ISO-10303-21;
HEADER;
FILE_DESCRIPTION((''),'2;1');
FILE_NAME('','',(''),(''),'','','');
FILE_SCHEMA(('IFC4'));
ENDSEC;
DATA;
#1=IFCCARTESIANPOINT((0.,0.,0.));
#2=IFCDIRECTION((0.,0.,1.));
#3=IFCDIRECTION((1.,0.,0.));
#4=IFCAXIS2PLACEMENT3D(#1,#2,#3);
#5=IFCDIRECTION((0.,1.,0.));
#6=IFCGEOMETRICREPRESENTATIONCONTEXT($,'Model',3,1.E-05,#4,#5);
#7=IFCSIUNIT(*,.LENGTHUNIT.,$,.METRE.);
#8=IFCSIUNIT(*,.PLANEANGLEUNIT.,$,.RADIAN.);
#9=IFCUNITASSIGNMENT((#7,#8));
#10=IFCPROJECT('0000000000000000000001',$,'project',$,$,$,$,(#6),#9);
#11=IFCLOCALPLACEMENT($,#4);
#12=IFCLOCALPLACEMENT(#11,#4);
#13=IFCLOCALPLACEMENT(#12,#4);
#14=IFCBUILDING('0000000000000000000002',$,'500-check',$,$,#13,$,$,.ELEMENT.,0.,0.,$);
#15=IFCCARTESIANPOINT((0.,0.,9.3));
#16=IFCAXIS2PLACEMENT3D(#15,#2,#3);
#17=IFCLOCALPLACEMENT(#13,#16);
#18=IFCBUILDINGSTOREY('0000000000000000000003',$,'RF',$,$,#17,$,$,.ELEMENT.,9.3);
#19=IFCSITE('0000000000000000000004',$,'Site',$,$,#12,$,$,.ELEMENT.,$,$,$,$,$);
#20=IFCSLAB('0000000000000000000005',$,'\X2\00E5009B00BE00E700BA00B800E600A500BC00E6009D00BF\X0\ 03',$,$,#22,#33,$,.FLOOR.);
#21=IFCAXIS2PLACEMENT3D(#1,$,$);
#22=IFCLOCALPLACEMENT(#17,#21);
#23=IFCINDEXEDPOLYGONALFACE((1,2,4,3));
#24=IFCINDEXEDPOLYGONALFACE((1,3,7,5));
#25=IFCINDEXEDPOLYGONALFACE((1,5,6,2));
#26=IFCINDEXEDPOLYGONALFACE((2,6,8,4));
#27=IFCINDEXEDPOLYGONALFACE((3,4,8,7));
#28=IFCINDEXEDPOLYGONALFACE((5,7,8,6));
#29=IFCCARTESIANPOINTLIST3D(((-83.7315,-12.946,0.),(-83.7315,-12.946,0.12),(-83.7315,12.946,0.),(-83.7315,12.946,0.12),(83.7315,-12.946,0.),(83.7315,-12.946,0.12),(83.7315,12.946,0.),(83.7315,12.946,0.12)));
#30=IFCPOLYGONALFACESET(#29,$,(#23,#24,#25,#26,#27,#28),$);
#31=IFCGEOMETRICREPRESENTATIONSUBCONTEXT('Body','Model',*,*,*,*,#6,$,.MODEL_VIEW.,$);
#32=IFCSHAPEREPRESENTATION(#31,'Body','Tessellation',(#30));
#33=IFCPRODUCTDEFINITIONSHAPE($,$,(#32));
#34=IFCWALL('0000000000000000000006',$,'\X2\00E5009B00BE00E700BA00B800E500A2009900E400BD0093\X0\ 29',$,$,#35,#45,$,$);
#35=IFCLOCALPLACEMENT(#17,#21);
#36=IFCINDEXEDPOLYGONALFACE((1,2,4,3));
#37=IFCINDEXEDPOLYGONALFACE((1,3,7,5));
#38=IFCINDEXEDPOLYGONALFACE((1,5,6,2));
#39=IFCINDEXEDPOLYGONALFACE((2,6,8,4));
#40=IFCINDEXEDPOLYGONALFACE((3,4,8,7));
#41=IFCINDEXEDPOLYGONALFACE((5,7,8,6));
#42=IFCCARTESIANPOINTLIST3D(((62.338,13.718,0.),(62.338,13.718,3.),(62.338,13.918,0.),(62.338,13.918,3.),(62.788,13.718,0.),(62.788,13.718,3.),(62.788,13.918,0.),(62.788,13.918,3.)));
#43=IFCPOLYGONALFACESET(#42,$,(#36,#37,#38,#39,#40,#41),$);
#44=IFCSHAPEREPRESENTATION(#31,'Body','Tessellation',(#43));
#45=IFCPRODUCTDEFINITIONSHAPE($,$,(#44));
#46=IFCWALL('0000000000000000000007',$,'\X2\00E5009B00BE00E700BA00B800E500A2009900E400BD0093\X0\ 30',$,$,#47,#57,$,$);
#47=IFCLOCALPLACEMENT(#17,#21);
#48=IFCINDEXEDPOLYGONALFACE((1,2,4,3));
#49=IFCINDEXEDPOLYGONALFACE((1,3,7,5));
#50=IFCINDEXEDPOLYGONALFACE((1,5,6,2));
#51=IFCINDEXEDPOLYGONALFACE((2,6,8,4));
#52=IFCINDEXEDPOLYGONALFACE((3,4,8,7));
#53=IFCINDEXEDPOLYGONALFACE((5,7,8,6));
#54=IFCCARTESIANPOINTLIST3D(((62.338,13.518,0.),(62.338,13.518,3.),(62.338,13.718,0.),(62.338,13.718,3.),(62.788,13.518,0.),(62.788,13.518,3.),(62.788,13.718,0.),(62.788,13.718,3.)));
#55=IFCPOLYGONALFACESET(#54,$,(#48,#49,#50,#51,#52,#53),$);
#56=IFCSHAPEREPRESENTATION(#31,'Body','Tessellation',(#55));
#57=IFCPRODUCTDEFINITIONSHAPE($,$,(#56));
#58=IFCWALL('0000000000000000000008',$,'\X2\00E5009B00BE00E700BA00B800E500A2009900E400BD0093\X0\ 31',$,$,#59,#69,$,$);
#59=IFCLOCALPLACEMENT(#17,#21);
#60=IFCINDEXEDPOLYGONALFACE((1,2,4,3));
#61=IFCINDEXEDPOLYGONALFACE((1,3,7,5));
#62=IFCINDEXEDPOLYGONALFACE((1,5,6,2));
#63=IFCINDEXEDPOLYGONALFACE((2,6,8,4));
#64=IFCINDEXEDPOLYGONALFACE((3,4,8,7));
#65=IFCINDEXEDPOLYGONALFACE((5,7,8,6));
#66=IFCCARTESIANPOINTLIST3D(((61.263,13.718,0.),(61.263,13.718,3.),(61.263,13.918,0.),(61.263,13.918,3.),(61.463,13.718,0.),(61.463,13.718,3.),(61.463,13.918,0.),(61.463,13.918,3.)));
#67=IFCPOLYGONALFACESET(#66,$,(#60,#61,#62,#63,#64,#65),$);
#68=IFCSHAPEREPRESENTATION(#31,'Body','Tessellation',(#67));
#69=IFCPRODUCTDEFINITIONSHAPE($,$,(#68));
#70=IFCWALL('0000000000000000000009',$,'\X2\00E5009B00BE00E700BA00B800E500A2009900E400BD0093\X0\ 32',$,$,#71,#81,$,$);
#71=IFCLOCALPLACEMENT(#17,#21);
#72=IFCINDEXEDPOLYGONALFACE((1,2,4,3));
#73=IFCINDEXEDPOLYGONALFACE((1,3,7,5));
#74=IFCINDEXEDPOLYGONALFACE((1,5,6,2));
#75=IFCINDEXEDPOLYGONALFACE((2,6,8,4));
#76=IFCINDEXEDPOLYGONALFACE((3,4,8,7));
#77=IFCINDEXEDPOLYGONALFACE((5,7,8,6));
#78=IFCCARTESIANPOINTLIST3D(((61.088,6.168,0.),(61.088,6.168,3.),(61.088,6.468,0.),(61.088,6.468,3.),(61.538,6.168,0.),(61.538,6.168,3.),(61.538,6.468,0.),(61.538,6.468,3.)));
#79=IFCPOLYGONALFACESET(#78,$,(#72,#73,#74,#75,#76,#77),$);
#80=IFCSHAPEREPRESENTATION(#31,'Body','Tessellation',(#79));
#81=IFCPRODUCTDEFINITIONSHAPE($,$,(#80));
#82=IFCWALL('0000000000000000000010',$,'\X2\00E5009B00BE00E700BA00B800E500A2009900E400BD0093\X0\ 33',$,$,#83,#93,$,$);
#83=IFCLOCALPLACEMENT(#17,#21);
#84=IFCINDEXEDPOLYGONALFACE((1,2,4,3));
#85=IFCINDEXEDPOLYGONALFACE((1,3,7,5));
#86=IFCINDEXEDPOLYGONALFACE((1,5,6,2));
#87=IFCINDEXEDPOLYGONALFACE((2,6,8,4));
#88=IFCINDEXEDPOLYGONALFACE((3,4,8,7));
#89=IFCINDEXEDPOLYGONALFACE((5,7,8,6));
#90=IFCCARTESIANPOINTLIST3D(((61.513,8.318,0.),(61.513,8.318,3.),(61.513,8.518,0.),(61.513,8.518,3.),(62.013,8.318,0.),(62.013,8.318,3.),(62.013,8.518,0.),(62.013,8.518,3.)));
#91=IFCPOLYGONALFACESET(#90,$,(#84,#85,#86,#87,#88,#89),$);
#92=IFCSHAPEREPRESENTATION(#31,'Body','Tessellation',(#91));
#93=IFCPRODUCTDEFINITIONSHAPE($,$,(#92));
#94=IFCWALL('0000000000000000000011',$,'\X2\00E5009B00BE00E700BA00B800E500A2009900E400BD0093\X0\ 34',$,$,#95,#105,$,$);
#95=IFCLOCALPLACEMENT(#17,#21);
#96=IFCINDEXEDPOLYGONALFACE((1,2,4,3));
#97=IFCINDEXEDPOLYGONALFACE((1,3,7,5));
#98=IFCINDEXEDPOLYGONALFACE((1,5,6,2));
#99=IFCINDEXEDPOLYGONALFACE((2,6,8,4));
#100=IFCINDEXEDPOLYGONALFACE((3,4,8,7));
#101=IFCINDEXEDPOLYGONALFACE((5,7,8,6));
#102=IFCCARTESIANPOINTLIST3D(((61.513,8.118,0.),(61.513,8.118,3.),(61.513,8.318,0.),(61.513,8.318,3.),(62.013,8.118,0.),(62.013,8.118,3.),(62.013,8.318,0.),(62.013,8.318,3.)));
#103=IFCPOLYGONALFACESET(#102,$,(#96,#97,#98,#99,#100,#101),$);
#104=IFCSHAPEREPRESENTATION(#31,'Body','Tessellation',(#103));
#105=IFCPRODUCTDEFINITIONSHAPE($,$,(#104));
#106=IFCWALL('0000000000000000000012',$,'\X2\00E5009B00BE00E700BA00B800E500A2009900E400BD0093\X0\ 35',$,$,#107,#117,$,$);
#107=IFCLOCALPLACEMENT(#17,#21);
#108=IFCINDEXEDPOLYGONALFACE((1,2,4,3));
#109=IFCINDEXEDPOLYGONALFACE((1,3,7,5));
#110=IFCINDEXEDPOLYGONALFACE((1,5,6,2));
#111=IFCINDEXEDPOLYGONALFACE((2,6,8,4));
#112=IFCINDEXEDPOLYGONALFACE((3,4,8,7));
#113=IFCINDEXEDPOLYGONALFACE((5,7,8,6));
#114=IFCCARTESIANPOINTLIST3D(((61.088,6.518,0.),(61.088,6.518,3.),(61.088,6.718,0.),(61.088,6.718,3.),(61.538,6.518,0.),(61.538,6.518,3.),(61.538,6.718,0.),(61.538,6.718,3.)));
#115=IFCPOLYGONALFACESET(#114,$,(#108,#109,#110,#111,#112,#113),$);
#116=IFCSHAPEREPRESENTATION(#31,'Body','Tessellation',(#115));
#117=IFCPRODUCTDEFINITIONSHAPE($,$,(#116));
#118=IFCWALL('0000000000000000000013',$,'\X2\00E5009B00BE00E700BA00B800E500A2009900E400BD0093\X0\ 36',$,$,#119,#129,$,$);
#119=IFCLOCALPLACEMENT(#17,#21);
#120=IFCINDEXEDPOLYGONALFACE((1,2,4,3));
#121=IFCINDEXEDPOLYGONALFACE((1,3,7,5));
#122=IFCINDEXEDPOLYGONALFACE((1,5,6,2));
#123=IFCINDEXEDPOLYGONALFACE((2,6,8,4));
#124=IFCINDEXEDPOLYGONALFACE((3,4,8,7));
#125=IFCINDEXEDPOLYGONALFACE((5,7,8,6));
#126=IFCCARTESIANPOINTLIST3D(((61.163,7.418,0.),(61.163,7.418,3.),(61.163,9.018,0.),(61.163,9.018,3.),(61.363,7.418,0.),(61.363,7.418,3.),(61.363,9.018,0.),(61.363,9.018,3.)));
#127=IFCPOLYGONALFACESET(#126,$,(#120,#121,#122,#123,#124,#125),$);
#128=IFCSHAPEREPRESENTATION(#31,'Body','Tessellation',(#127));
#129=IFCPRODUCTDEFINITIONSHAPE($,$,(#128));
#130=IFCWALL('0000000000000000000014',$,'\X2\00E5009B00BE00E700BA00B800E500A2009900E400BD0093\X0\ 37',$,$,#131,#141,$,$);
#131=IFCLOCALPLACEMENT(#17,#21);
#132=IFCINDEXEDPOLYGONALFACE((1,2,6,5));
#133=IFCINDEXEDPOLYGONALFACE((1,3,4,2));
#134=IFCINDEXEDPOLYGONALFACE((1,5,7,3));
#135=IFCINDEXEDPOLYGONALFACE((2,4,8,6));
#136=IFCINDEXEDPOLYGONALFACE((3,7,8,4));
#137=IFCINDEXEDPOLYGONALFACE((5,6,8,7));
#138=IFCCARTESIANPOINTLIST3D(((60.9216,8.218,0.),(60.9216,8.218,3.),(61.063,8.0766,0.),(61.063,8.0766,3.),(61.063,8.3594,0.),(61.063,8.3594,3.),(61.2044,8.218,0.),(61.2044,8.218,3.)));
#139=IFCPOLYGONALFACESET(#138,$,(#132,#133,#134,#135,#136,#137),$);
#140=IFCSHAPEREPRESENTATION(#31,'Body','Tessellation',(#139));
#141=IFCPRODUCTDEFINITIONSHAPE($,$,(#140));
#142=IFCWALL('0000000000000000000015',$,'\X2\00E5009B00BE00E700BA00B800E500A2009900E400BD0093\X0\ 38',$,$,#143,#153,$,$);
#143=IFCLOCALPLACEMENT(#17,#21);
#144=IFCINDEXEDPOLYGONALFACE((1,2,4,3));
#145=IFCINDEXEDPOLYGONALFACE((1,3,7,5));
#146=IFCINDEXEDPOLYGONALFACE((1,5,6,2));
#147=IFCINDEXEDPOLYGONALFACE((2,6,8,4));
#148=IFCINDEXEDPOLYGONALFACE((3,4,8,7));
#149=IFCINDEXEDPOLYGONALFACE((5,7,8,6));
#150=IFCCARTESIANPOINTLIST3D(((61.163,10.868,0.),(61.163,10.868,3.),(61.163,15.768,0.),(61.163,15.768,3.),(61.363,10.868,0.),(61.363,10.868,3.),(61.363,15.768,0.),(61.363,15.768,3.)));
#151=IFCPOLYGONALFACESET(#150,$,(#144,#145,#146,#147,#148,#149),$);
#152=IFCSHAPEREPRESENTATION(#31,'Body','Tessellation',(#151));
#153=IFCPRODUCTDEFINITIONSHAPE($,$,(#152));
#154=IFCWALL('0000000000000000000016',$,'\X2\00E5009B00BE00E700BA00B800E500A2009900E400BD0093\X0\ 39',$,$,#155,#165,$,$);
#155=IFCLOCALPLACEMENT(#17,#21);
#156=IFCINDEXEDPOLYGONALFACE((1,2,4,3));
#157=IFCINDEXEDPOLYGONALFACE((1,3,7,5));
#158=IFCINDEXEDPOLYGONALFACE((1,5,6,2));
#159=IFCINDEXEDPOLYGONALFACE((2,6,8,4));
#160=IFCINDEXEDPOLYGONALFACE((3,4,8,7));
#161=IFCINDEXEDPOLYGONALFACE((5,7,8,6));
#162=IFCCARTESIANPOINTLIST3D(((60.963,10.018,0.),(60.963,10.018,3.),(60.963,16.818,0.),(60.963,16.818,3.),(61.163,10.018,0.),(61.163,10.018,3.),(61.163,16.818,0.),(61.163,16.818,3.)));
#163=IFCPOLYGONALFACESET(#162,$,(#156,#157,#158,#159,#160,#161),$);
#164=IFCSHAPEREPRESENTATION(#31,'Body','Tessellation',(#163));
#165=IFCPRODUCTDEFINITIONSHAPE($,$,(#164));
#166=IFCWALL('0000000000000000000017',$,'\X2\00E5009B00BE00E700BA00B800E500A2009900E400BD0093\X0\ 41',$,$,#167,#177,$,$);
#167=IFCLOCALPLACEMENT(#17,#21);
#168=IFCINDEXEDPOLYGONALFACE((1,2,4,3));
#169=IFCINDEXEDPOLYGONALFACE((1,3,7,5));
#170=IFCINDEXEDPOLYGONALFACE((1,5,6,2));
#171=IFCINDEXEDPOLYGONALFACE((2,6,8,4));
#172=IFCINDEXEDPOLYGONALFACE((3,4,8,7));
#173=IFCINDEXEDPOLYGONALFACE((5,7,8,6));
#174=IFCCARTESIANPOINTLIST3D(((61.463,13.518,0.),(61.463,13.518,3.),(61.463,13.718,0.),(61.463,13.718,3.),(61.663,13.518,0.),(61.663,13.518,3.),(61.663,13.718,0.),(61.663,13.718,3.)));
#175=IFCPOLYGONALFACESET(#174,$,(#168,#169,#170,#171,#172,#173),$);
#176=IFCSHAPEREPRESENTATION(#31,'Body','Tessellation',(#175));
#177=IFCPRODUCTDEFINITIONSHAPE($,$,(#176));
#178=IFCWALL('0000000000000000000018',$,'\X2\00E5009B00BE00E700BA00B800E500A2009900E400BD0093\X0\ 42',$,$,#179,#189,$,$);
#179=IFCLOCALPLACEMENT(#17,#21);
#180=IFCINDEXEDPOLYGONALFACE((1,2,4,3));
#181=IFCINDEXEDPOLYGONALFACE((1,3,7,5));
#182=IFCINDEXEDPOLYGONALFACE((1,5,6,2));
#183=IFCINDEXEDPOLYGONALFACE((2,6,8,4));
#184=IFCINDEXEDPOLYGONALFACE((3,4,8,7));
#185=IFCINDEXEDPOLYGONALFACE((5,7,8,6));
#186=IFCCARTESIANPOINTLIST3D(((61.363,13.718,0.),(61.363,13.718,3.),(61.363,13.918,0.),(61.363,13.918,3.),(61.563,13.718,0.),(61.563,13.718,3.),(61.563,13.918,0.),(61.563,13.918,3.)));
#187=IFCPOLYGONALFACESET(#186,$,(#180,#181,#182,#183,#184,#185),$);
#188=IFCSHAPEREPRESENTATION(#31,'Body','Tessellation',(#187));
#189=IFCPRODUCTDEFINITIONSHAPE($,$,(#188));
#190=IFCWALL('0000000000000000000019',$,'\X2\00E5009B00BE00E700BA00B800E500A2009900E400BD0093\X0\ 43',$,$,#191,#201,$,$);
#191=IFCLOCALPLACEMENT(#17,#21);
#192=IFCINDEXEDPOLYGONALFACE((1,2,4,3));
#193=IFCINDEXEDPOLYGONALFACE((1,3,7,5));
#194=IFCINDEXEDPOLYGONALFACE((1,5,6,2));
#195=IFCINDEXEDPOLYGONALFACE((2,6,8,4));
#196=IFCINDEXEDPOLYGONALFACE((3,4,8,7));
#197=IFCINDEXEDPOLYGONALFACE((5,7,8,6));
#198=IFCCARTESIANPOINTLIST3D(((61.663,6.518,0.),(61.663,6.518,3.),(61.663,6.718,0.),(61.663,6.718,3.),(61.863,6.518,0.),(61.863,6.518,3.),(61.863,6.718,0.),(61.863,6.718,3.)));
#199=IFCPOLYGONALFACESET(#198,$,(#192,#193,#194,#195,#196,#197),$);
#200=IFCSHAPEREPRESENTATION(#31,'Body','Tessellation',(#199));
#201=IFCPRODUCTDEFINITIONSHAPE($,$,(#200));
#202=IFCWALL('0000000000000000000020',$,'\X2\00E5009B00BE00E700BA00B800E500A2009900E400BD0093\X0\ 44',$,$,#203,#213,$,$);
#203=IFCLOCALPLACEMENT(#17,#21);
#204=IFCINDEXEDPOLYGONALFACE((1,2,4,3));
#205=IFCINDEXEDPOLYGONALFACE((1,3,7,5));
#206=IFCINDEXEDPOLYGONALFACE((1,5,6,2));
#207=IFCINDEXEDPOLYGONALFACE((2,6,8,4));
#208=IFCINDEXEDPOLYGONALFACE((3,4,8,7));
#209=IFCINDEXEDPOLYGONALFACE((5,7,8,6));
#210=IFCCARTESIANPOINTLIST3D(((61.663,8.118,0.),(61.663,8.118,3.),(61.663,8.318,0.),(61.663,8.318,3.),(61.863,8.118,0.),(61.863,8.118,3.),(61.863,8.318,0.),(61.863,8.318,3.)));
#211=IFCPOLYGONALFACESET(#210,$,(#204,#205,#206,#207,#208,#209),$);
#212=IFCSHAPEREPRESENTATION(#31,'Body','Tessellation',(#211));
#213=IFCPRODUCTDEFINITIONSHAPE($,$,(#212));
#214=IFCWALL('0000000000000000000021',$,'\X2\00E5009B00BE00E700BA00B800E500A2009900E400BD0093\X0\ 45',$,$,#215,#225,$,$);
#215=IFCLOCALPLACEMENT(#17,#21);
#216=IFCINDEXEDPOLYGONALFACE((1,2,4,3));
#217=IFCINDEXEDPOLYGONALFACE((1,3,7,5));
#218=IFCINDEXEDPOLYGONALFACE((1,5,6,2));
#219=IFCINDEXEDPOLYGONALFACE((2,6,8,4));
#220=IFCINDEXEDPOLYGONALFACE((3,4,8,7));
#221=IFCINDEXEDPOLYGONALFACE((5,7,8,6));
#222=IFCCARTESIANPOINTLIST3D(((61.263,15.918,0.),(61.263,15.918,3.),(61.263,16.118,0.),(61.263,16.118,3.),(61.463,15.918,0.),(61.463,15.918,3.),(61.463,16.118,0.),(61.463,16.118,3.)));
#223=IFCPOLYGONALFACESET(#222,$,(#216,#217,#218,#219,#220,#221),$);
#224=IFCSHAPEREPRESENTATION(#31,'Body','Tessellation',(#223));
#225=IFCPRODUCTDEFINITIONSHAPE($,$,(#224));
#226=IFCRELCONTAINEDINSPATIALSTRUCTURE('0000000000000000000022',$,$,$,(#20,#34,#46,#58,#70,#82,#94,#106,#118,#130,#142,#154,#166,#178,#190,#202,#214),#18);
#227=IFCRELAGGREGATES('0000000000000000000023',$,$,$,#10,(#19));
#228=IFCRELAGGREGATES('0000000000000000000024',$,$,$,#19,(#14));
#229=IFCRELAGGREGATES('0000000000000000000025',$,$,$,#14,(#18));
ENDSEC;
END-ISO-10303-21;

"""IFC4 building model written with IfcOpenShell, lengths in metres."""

from ifc_helpers import new_model, si_unit, direction, frame, frame_2d, origin_with_axes, place, context, subcontext, project, spatial, rectangle, extrude, element, save


model = new_model("IFC4")

# Units and contexts
model_context = context("Model", 3, precision=1e-05, world=origin_with_axes(), true_north=direction((0.0, 1.0, 0.0)))
body_context = subcontext(model_context, "Body", "Model", "MODEL_VIEW")
ifc_project = project(units=[si_unit("LENGTHUNIT", "METRE"), si_unit("PLANEANGLEUNIT", "RADIAN")], contexts=[model_context])

# Site, building, storey
placement = place(None, origin_with_axes())
site_placement = place(placement, origin_with_axes())
site = spatial("IfcSite", under=ifc_project, at=site_placement, Name="Site", CompositionType="ELEMENT")
building_placement = place(site_placement, origin_with_axes())
building = spatial("IfcBuilding", under=site, at=building_placement, Name="500-check", CompositionType="ELEMENT", ElevationOfRefHeight=0.0, ElevationOfTerrain=0.0)
storey_placement = place(building_placement, frame((0.0, 0.0, 9.3), z_axis=(0.0, 0.0, 1.0), x_axis=(1.0, 0.0, 0.0)))
storey = spatial("IfcBuildingStorey", under=building, at=storey_placement, Name="RF", CompositionType="ELEMENT", Elevation=9.3)

# Slab
slab_placement = place(storey_placement, origin_with_axes())
element("IfcSlab", 1, at=slab_placement, inside=storey, Name="å\u009b¾çº¸æ¥¼æ\u009d¿ 03", PredefinedType="FLOOR", context=body_context, shape_type="SweptSolid", body=[
    extrude(rectangle(XDim=167.463, YDim=25.892, at=frame_2d((0.0, 0.0), x_axis=(1.0, 0.0, 0.0))), frame((0.0, 0.0, 0.0), z_axis=(0.0, 0.0, 1.0)), (0.0, 0.0, 1.0), 0.12),
])

# Walls
for number, where, z_axis, x_axis, name in (
    (2, (62.563, 13.818, 0.0), (0.0, 0.0, 1.0), (1.0, 0.0, 0.0), "å\u009b¾çº¸å¢\u0099ä½\u0093 29"),
    (3, (62.563, 13.618, 0.0), (0.0, 0.0, 1.0), (1.0, 0.0, 0.0), "å\u009b¾çº¸å¢\u0099ä½\u0093 30"),
):
    element("IfcWall", number, at=place(storey_placement, frame(where, z_axis=z_axis, x_axis=x_axis)), inside=storey, Name=name, context=body_context, shape_type="SweptSolid", body=[
        extrude(rectangle(XDim=0.45, YDim=0.2, at=frame_2d((0.0, 0.0), x_axis=(1.0, 0.0, 0.0))), frame((0.0, 0.0, 0.0), z_axis=(0.0, 0.0, 1.0)), (0.0, 0.0, 1.0), 3.0),
    ])
wall_1_placement = place(storey_placement, frame((61.363, 13.818, 0.0), z_axis=(0.0, 0.0, 1.0), x_axis=(1.0, 0.0, 0.0)))
element("IfcWall", 4, at=wall_1_placement, inside=storey, Name="å\u009b¾çº¸å¢\u0099ä½\u0093 31", context=body_context, shape_type="SweptSolid", body=[
    extrude(rectangle(XDim=0.2, YDim=0.2, at=frame_2d((0.0, 0.0), x_axis=(1.0, 0.0, 0.0))), frame((0.0, 0.0, 0.0), z_axis=(0.0, 0.0, 1.0)), (0.0, 0.0, 1.0), 3.0),
])
wall_2_placement = place(storey_placement, frame((61.313, 6.318, 0.0), z_axis=(0.0, 0.0, 1.0), x_axis=(1.0, 0.0, 0.0)))
element("IfcWall", 5, at=wall_2_placement, inside=storey, Name="å\u009b¾çº¸å¢\u0099ä½\u0093 32", context=body_context, shape_type="SweptSolid", body=[
    extrude(rectangle(XDim=0.45, YDim=0.3, at=frame_2d((0.0, 0.0), x_axis=(1.0, 0.0, 0.0))), frame((0.0, 0.0, 0.0), z_axis=(0.0, 0.0, 1.0)), (0.0, 0.0, 1.0), 3.0),
])
for number, where, z_axis, x_axis, name in (
    (6, (61.763, 8.418, 0.0), (0.0, 0.0, 1.0), (-1.0, 0.0, 0.0), "å\u009b¾çº¸å¢\u0099ä½\u0093 33"),
    (7, (61.763, 8.218, 0.0), (0.0, 0.0, 1.0), (-1.0, 0.0, 0.0), "å\u009b¾çº¸å¢\u0099ä½\u0093 34"),
):
    element("IfcWall", number, at=place(storey_placement, frame(where, z_axis=z_axis, x_axis=x_axis)), inside=storey, Name=name, context=body_context, shape_type="SweptSolid", body=[
        extrude(rectangle(XDim=0.5, YDim=0.2, at=frame_2d((0.0, 0.0), x_axis=(1.0, 0.0, 0.0))), frame((0.0, 0.0, 0.0), z_axis=(0.0, 0.0, 1.0)), (0.0, 0.0, 1.0), 3.0),
    ])
wall_3_placement = place(storey_placement, frame((61.313, 6.618, 0.0), z_axis=(0.0, 0.0, 1.0), x_axis=(1.0, 0.0, 0.0)))
element("IfcWall", 8, at=wall_3_placement, inside=storey, Name="å\u009b¾çº¸å¢\u0099ä½\u0093 35", context=body_context, shape_type="SweptSolid", body=[
    extrude(rectangle(XDim=0.45, YDim=0.2, at=frame_2d((0.0, 0.0), x_axis=(1.0, 0.0, 0.0))), frame((0.0, 0.0, 0.0), z_axis=(0.0, 0.0, 1.0)), (0.0, 0.0, 1.0), 3.0),
])
wall_4_placement = place(storey_placement, frame((61.263, 8.218, 0.0), z_axis=(0.0, 0.0, 1.0), x_axis=(0.0, -1.0, 0.0)))
element("IfcWall", 9, at=wall_4_placement, inside=storey, Name="å\u009b¾çº¸å¢\u0099ä½\u0093 36", context=body_context, shape_type="SweptSolid", body=[
    extrude(rectangle(XDim=1.6, YDim=0.2, at=frame_2d((0.0, 0.0), x_axis=(1.0, 0.0, 0.0))), frame((0.0, 0.0, 0.0), z_axis=(0.0, 0.0, 1.0)), (0.0, 0.0, 1.0), 3.0),
])
wall_5_placement = place(storey_placement, frame((61.063, 8.218, 0.0), z_axis=(0.0, 0.0, 1.0), x_axis=(0.707107, -0.707107, 0.0)))
element("IfcWall", 10, at=wall_5_placement, inside=storey, Name="å\u009b¾çº¸å¢\u0099ä½\u0093 37", context=body_context, shape_type="SweptSolid", body=[
    extrude(rectangle(XDim=0.2, YDim=0.2, at=frame_2d((0.0, 0.0), x_axis=(1.0, 0.0, 0.0))), frame((0.0, 0.0, 0.0), z_axis=(0.0, 0.0, 1.0)), (0.0, 0.0, 1.0), 3.0),
])
wall_6_placement = place(storey_placement, frame((61.263, 13.318, 0.0), z_axis=(0.0, 0.0, 1.0), x_axis=(0.0, -1.0, 0.0)))
element("IfcWall", 11, at=wall_6_placement, inside=storey, Name="å\u009b¾çº¸å¢\u0099ä½\u0093 38", context=body_context, shape_type="SweptSolid", body=[
    extrude(rectangle(XDim=4.9, YDim=0.2, at=frame_2d((0.0, 0.0), x_axis=(1.0, 0.0, 0.0))), frame((0.0, 0.0, 0.0), z_axis=(0.0, 0.0, 1.0)), (0.0, 0.0, 1.0), 3.0),
])
wall_7_placement = place(storey_placement, frame((61.063, 13.418, 0.0), z_axis=(0.0, 0.0, 1.0), x_axis=(0.0, -1.0, 0.0)))
element("IfcWall", 12, at=wall_7_placement, inside=storey, Name="å\u009b¾çº¸å¢\u0099ä½\u0093 39", context=body_context, shape_type="SweptSolid", body=[
    extrude(rectangle(XDim=6.8, YDim=0.2, at=frame_2d((0.0, 0.0), x_axis=(1.0, 0.0, 0.0))), frame((0.0, 0.0, 0.0), z_axis=(0.0, 0.0, 1.0)), (0.0, 0.0, 1.0), 3.0),
])
for number, where, z_axis, x_axis, name in (
    (13, (61.563, 13.618, 0.0), (0.0, 0.0, 1.0), (0.0, 1.0, 0.0), "å\u009b¾çº¸å¢\u0099ä½\u0093 41"),
    (14, (61.463, 13.818, 0.0), (0.0, 0.0, 1.0), (1.0, 0.0, 0.0), "å\u009b¾çº¸å¢\u0099ä½\u0093 42"),
    (15, (61.763, 6.618, 0.0), (0.0, 0.0, 1.0), (0.0, -1.0, 0.0), "å\u009b¾çº¸å¢\u0099ä½\u0093 43"),
    (16, (61.763, 8.218, 0.0), (0.0, 0.0, 1.0), (0.0, 1.0, 0.0), "å\u009b¾çº¸å¢\u0099ä½\u0093 44"),
    (17, (61.363, 16.018, 0.0), (0.0, 0.0, 1.0), (1.0, 0.0, 0.0), "å\u009b¾çº¸å¢\u0099ä½\u0093 45"),
):
    element("IfcWall", number, at=place(storey_placement, frame(where, z_axis=z_axis, x_axis=x_axis)), inside=storey, Name=name, context=body_context, shape_type="SweptSolid", body=[
        extrude(rectangle(XDim=0.2, YDim=0.2, at=frame_2d((0.0, 0.0), x_axis=(1.0, 0.0, 0.0))), frame((0.0, 0.0, 0.0), z_axis=(0.0, 0.0, 1.0)), (0.0, 0.0, 1.0), 3.0),
    ])

save(model, "model.ifc")
